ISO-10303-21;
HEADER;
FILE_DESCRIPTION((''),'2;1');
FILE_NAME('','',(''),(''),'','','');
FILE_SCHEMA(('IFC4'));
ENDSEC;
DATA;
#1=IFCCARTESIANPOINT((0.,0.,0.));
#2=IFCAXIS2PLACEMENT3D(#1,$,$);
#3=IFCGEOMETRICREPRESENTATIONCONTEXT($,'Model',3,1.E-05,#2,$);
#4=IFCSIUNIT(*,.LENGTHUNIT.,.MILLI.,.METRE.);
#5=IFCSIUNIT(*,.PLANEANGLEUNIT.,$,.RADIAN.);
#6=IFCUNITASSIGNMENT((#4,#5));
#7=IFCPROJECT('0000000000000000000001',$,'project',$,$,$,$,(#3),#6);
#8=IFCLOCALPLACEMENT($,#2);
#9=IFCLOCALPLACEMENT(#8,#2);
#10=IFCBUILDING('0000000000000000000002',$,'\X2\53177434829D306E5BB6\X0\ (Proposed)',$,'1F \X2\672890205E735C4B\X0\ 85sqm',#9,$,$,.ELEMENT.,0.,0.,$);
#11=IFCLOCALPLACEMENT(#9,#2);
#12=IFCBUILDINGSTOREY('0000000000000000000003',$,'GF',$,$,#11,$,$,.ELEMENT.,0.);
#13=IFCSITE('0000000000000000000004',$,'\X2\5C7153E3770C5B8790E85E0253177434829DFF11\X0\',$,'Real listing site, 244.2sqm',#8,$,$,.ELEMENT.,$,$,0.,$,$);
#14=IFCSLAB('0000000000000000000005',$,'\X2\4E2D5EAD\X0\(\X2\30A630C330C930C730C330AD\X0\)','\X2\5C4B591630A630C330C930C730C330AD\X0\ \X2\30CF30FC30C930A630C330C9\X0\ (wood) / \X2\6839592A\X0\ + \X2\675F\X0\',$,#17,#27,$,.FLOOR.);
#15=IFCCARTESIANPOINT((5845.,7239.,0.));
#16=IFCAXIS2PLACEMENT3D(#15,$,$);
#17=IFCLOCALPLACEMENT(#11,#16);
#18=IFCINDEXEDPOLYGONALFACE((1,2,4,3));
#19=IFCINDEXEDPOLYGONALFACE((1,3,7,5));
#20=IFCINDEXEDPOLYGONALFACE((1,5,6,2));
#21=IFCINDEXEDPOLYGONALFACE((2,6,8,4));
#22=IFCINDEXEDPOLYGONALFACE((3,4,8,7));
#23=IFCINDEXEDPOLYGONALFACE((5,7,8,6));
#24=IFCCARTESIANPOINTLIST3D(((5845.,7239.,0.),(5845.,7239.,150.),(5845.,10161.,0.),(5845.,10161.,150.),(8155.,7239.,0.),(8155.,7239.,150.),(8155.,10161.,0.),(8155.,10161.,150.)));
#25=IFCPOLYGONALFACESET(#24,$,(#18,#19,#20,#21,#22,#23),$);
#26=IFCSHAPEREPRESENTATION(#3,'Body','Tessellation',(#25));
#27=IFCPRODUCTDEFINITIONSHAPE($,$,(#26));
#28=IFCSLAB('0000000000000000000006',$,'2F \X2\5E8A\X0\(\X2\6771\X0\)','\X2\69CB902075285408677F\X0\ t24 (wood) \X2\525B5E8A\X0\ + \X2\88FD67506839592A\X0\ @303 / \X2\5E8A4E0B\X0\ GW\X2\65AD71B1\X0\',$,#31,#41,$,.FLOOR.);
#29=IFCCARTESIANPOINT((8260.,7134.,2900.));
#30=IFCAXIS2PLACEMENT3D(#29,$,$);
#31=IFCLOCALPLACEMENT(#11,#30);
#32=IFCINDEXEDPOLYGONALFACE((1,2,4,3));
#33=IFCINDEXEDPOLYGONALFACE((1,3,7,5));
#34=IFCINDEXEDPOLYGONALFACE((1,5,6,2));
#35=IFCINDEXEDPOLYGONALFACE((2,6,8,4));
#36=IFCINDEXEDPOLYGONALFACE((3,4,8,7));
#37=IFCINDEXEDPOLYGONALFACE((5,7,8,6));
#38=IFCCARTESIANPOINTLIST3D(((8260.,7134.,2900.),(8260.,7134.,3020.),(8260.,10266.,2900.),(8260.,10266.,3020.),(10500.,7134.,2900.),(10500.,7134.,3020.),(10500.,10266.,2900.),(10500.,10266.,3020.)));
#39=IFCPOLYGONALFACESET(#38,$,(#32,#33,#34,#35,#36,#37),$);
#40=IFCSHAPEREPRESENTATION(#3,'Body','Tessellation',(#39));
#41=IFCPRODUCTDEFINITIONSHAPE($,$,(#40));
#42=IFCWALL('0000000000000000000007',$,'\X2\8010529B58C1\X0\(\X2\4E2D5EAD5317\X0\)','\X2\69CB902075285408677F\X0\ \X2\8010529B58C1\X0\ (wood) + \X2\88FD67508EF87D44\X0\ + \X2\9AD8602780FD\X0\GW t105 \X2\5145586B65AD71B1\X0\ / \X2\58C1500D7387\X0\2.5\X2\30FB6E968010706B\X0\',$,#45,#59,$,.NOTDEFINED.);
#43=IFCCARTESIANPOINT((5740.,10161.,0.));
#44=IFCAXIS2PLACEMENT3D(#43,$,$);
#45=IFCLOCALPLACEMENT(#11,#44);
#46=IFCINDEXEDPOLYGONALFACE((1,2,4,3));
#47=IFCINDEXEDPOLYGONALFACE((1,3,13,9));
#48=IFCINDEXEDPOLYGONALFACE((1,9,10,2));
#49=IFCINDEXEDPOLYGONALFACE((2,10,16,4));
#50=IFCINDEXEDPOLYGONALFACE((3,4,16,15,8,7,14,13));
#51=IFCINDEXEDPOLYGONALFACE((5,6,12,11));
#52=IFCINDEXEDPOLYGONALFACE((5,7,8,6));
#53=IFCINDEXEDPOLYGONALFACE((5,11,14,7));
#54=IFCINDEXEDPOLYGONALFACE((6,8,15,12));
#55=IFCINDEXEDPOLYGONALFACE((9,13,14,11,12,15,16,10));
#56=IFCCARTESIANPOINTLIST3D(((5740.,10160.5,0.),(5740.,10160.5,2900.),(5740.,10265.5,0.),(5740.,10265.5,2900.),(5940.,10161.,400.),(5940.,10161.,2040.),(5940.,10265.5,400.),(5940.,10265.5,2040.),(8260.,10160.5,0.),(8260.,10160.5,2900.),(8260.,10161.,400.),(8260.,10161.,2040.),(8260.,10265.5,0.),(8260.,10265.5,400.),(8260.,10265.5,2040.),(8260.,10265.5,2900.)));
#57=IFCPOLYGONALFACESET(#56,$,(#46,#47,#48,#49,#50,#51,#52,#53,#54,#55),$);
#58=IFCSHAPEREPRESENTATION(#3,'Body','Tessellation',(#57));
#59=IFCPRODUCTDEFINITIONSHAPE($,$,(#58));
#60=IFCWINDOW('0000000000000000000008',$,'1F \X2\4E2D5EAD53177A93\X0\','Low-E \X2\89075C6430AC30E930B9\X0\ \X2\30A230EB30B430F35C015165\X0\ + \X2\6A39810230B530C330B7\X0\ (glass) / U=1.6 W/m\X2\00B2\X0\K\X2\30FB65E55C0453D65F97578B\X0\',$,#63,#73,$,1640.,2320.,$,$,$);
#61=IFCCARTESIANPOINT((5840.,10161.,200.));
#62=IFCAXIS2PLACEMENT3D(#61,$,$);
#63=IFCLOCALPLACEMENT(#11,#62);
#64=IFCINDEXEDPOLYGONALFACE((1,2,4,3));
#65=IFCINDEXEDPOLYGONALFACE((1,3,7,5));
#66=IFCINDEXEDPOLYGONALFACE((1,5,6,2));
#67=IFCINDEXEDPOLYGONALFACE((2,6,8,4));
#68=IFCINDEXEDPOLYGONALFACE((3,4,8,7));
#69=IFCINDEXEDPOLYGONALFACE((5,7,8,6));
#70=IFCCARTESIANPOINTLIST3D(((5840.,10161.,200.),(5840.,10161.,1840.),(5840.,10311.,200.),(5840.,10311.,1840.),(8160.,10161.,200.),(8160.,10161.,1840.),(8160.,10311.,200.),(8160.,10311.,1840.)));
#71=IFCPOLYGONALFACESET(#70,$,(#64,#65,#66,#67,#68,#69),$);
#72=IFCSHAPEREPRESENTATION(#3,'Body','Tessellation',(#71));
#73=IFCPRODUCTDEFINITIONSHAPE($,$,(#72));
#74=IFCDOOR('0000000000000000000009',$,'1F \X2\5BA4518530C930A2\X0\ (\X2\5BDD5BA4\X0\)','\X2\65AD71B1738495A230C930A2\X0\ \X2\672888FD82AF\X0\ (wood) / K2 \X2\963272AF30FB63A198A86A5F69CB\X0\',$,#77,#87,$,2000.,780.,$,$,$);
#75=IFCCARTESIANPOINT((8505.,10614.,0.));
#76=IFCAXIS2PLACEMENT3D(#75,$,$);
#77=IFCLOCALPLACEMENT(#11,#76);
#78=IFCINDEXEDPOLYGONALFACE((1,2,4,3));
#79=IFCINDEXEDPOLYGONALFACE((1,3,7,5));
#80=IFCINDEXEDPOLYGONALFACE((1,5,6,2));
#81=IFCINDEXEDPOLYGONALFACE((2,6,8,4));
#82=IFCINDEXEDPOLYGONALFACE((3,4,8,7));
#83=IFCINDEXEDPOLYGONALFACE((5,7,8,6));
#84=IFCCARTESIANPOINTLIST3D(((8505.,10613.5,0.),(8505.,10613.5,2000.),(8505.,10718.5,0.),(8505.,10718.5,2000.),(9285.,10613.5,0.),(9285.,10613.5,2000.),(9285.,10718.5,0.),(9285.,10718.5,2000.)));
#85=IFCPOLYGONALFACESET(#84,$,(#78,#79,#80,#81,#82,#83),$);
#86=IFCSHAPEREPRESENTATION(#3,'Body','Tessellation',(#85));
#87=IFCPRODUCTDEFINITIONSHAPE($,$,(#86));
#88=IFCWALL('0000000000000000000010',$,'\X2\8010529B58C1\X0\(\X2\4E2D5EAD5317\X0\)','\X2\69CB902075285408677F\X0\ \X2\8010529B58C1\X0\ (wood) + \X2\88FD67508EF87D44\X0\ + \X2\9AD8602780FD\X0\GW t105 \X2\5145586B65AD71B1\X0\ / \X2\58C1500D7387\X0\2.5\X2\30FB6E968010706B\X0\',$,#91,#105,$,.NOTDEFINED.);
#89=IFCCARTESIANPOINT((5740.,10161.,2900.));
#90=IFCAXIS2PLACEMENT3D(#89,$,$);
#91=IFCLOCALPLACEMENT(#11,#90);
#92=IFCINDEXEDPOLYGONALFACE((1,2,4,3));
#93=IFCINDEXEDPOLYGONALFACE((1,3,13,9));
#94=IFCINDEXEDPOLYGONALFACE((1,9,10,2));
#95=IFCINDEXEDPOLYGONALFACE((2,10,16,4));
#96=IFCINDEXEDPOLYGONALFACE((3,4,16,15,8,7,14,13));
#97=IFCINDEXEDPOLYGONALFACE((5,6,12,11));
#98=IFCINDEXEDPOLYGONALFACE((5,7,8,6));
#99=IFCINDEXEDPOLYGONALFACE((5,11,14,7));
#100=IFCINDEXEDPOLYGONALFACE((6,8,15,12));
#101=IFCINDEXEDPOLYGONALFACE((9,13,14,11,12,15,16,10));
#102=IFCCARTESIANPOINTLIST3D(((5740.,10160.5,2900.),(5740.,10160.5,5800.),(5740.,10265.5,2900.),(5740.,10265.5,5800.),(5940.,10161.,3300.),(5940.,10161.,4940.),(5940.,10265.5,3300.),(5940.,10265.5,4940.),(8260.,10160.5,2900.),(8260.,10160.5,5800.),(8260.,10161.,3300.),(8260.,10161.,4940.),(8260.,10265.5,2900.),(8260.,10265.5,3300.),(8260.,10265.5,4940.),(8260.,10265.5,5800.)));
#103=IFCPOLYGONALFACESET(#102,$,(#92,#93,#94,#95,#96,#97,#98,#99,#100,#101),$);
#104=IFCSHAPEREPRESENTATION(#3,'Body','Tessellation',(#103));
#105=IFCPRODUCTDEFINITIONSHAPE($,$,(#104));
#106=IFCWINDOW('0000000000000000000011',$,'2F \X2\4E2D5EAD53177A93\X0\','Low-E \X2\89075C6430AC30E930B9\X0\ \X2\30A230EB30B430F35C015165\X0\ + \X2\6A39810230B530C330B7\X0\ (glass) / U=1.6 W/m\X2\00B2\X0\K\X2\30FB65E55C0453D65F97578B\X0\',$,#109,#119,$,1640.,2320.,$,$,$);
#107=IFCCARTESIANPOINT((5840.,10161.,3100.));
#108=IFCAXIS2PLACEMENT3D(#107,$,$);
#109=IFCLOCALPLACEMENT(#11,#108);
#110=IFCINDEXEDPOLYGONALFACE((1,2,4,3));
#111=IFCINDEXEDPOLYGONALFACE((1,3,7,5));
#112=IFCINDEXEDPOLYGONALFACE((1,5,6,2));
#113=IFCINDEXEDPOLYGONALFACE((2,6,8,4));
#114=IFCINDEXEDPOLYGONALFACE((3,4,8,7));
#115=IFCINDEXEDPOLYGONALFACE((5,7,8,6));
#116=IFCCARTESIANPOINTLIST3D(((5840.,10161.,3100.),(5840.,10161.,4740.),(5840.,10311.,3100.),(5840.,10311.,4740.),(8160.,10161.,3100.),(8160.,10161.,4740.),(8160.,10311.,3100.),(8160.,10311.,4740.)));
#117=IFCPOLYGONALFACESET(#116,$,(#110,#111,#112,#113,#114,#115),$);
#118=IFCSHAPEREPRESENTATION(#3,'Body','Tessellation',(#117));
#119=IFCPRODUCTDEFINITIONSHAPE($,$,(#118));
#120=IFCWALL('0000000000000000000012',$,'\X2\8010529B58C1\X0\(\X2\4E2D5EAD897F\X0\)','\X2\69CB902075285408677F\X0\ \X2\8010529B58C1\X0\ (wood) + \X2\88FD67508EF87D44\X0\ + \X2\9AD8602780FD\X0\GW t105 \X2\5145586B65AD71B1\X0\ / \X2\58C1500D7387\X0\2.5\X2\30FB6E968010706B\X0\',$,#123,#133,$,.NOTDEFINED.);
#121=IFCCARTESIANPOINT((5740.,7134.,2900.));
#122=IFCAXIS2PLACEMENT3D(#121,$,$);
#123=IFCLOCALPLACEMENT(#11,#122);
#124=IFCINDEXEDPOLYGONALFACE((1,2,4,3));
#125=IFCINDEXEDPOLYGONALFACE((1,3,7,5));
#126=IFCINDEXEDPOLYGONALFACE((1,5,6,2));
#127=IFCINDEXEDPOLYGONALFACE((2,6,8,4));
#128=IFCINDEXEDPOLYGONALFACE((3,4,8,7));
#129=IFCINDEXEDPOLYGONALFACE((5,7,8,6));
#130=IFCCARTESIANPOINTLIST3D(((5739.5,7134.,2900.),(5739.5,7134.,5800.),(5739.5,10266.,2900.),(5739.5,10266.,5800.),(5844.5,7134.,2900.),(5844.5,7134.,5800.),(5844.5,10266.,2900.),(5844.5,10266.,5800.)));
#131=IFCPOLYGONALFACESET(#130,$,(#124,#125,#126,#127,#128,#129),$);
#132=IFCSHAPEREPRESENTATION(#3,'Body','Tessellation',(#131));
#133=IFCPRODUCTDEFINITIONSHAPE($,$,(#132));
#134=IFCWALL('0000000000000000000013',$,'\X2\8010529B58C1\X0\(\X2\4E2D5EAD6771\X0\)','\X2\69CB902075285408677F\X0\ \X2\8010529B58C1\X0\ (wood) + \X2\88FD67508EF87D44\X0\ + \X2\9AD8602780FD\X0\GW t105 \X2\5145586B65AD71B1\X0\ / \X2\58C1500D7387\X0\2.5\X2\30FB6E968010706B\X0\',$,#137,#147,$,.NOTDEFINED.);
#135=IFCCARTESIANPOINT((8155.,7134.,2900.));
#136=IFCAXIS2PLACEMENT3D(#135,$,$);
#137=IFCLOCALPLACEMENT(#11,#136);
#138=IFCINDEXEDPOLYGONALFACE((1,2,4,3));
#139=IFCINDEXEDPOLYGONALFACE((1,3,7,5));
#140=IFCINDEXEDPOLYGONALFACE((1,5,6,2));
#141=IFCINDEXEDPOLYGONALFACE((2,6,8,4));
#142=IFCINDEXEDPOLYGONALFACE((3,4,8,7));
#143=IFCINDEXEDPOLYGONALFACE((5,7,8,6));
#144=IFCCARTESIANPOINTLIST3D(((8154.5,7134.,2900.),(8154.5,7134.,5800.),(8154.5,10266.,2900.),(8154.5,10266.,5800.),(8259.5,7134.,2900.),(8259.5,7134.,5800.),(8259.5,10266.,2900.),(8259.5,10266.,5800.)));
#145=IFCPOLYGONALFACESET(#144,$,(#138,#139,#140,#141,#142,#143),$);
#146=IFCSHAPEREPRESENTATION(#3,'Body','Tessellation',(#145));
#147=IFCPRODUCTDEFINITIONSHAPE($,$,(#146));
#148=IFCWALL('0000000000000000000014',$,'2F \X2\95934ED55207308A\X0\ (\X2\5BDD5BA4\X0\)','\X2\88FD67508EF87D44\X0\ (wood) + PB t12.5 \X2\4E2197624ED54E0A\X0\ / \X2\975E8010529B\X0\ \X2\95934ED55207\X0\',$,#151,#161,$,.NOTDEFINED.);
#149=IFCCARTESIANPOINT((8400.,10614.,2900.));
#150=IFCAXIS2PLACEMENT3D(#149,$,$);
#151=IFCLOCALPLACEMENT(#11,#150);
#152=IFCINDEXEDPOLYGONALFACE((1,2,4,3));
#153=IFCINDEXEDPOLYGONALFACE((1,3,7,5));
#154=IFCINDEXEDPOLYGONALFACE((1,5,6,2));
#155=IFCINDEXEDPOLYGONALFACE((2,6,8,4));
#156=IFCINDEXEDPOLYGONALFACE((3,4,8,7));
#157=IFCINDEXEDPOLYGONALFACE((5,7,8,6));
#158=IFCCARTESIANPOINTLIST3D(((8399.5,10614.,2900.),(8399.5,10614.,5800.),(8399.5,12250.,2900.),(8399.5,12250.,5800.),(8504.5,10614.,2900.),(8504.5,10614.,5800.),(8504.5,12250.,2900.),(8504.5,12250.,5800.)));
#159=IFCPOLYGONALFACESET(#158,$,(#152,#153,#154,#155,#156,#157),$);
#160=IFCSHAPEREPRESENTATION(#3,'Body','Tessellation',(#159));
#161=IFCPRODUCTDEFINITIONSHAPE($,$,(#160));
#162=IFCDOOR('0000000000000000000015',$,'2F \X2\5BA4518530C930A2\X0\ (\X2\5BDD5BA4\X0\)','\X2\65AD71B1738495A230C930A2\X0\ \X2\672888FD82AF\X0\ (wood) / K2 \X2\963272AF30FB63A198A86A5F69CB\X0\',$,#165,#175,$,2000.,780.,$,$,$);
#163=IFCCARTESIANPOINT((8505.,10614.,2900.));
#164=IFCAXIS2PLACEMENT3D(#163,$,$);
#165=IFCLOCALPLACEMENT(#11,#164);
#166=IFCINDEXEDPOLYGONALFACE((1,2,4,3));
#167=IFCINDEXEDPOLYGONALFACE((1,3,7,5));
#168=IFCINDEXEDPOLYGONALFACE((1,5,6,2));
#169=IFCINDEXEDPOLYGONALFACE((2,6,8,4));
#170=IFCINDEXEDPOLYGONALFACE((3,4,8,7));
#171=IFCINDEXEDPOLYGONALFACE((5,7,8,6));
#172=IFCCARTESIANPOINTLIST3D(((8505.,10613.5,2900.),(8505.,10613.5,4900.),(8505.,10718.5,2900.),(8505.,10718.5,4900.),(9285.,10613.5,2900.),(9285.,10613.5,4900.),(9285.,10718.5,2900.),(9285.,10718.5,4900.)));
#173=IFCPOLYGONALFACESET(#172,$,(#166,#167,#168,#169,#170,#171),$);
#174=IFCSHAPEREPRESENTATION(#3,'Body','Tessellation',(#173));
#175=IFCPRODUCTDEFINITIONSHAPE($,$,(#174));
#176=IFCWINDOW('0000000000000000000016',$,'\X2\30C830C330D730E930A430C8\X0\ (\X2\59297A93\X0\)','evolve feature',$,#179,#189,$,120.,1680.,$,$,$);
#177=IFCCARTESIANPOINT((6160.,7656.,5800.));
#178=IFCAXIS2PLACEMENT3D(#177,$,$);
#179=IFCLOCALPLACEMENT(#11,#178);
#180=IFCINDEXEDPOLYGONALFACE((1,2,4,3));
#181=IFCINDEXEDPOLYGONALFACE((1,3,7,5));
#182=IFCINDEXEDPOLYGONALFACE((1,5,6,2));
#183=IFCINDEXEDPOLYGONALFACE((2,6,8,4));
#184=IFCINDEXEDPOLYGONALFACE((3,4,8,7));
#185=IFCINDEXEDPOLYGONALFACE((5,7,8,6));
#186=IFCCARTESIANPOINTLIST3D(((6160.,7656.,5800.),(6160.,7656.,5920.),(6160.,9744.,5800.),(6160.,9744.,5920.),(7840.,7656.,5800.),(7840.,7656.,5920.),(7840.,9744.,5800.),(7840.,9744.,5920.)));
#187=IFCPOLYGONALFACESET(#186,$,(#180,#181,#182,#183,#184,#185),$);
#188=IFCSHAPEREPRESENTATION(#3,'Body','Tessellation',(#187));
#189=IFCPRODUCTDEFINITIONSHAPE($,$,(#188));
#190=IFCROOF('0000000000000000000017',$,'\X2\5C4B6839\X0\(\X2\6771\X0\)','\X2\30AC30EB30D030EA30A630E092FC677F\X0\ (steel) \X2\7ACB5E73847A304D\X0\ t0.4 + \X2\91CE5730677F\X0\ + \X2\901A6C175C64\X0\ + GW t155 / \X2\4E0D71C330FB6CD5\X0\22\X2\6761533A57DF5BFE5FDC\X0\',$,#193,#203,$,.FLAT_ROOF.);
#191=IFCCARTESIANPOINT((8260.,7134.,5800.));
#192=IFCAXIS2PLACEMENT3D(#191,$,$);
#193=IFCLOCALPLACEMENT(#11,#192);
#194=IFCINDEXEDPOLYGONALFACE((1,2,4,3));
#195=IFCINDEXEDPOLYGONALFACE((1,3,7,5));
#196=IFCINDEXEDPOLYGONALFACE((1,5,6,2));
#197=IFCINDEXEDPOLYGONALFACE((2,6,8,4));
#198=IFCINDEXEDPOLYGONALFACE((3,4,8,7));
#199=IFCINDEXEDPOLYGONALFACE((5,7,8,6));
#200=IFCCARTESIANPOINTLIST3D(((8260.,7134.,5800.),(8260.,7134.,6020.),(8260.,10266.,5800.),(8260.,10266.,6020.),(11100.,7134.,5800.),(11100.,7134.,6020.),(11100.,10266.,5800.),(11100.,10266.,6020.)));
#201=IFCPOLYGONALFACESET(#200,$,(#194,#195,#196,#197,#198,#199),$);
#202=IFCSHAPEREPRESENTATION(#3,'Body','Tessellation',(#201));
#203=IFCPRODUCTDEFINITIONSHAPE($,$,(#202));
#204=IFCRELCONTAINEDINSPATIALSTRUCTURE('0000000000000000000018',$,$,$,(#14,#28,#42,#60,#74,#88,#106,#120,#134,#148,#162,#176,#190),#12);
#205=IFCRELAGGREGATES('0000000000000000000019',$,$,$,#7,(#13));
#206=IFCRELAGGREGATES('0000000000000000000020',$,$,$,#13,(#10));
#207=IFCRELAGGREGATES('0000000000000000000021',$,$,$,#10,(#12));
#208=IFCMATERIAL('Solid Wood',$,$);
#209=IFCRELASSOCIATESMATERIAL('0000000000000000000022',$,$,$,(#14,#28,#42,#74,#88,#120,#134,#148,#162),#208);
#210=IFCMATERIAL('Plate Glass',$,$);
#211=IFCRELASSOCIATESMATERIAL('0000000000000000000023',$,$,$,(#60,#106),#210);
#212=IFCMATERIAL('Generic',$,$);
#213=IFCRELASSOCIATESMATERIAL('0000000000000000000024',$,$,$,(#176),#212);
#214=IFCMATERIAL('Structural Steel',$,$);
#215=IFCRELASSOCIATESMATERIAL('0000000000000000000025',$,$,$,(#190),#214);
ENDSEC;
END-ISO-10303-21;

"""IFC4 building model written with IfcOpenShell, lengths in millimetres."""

from ifc_helpers import new_model, si_unit, frame, frame_2d, origin, place, context, project, spatial, rectangle, extrude, material, element, fill, save


model = new_model("IFC4")

# Units and contexts
model_context = context("Model", 3, precision=1e-05, world=origin())
ifc_project = project(units=[si_unit("LENGTHUNIT", "METRE", prefix="MILLI"), si_unit("PLANEANGLEUNIT", "RADIAN")], contexts=[model_context])

# Site, building, storey
site_placement = place(None, origin())
site = spatial("IfcSite", under=ifc_project, at=site_placement, Name="山口県宇部市北琴芝１", ObjectType="Real listing site, 244.2sqm", CompositionType="ELEMENT", RefElevation=0.0)
building_placement = place(site_placement, origin())
building = spatial("IfcBuilding", under=site, at=building_placement, Name="北琴芝の家 (Proposed)", ObjectType="1F 木造平屋 85sqm", CompositionType="ELEMENT", ElevationOfRefHeight=0.0, ElevationOfTerrain=0.0)
storey_placement = place(building_placement, origin())
storey = spatial("IfcBuildingStorey", under=building, at=storey_placement, Name="GF", CompositionType="ELEMENT", Elevation=0.0)

# Slabs
ifc_material_1 = material(Name="Solid Wood")
slab_1_placement = place(storey_placement, frame((5845.0, 7239.0, 0.0)))
element("IfcSlab", 1, at=slab_1_placement, inside=storey, material=ifc_material_1, Name="中庭(ウッドデッキ)", Description="屋外ウッドデッキ ハードウッド (wood) / 根太 + 束", PredefinedType="FLOOR", context=model_context, shape_type="SweptSolid", body=[
    extrude(rectangle(XDim=2310.0, YDim=2922.0, at=frame_2d((1155.0, 1461.0))), frame((5845.0, 7239.0, 0.0)), (0.0, 0.0, 1.0), 150.0),
])
slab_2_placement = place(storey_placement, frame((8260.0, 7134.0, 2900.0)))
element("IfcSlab", 2, at=slab_2_placement, inside=storey, material=ifc_material_1, Name="2F 床(東)", Description="構造用合板 t24 (wood) 剛床 + 製材根太 @303 / 床下 GW断熱", PredefinedType="FLOOR", context=model_context, shape_type="SweptSolid", body=[
    extrude(rectangle(XDim=2240.0, YDim=3132.0, at=frame_2d((1120.0, 1566.0))), frame((8260.0, 7134.0, 2900.0)), (0.0, 0.0, 1.0), 120.0),
])

# Wall, opening, window
wall_1_placement = place(storey_placement, frame((5740.0, 10161.0, 0.0)))
wall_1 = element("IfcWall", 3, at=wall_1_placement, inside=storey, material=ifc_material_1, Name="耐力壁(中庭北)", Description="構造用合板 耐力壁 (wood) + 製材軸組 + 高性能GW t105 充填断熱 / 壁倍率2.5・準耐火", PredefinedType="NOTDEFINED", context=model_context, shape_type="SweptSolid", body=[
    extrude(rectangle(XDim=2520.0, YDim=105.0, at=frame_2d((1260.0, 52.0))), frame((5740.0, 10161.0, 0.0)), (0.0, 0.0, 1.0), 2900.0),
])
opening_1_placement = place(storey_placement, frame((5840.0, 10161.0, 200.0)))
opening_1 = element("IfcOpeningElement", 4, at=opening_1_placement, cuts=wall_1, PredefinedType="NOTDEFINED", context=model_context, shape_type="SweptSolid", body=[
    extrude(rectangle(XDim=2320.0, YDim=150.0, at=frame_2d((1160.0, 75.0))), frame((5840.0, 10161.0, 200.0)), (0.0, 0.0, 1.0), 1640.0),
])
ifc_material_2 = material(Name="Plate Glass")
window_1_placement = place(storey_placement, frame((5840.0, 10161.0, 200.0)))
window_1 = element("IfcWindow", 5, at=window_1_placement, inside=storey, material=ifc_material_2, Name="1F 中庭北窓", Description="Low-E 複層ガラス アルゴン封入 + 樹脂サッシ (glass) / U=1.6 W/m²K・日射取得型", OverallHeight=1640.0, OverallWidth=2320.0, context=model_context, shape_type="SweptSolid", body=[
    extrude(rectangle(XDim=2320.0, YDim=150.0, at=frame_2d((1160.0, 75.0))), frame((5840.0, 10161.0, 200.0)), (0.0, 0.0, 1.0), 1640.0),
])
fill(opening_1, window_1)

# Door
door_1_placement = place(storey_placement, frame((8505.0, 10614.0, 0.0)))
element("IfcDoor", 6, at=door_1_placement, inside=storey, material=ifc_material_1, Name="1F 室内ドア (寝室)", Description="断熱玄関ドア 木製芯 (wood) / K2 防犯・採風機構", OverallHeight=2000.0, OverallWidth=780.0, context=model_context, shape_type="SweptSolid", body=[
    extrude(rectangle(XDim=780.0, YDim=105.0, at=frame_2d((390.0, 52.0))), frame((8505.0, 10614.0, 0.0)), (0.0, 0.0, 1.0), 2000.0),
])

# Wall, opening, window
wall_2_placement = place(storey_placement, frame((5740.0, 10161.0, 2900.0)))
wall_2 = element("IfcWall", 7, at=wall_2_placement, inside=storey, material=ifc_material_1, Name="耐力壁(中庭北)", Description="構造用合板 耐力壁 (wood) + 製材軸組 + 高性能GW t105 充填断熱 / 壁倍率2.5・準耐火", PredefinedType="NOTDEFINED", context=model_context, shape_type="SweptSolid", body=[
    extrude(rectangle(XDim=2520.0, YDim=105.0, at=frame_2d((1260.0, 52.0))), frame((5740.0, 10161.0, 2900.0)), (0.0, 0.0, 1.0), 2900.0),
])
opening_2_placement = place(storey_placement, frame((5840.0, 10161.0, 3100.0)))
opening_2 = element("IfcOpeningElement", 8, at=opening_2_placement, cuts=wall_2, PredefinedType="NOTDEFINED", context=model_context, shape_type="SweptSolid", body=[
    extrude(rectangle(XDim=2320.0, YDim=150.0, at=frame_2d((1160.0, 75.0))), frame((5840.0, 10161.0, 3100.0)), (0.0, 0.0, 1.0), 1640.0),
])
window_2_placement = place(storey_placement, frame((5840.0, 10161.0, 3100.0)))
window_2 = element("IfcWindow", 9, at=window_2_placement, inside=storey, material=ifc_material_2, Name="2F 中庭北窓", Description="Low-E 複層ガラス アルゴン封入 + 樹脂サッシ (glass) / U=1.6 W/m²K・日射取得型", OverallHeight=1640.0, OverallWidth=2320.0, context=model_context, shape_type="SweptSolid", body=[
    extrude(rectangle(XDim=2320.0, YDim=150.0, at=frame_2d((1160.0, 75.0))), frame((5840.0, 10161.0, 3100.0)), (0.0, 0.0, 1.0), 1640.0),
])
fill(opening_2, window_2)

# Walls
wall_3_placement = place(storey_placement, frame((5740.0, 7134.0, 2900.0)))
element("IfcWall", 10, at=wall_3_placement, inside=storey, material=ifc_material_1, Name="耐力壁(中庭西)", Description="構造用合板 耐力壁 (wood) + 製材軸組 + 高性能GW t105 充填断熱 / 壁倍率2.5・準耐火", PredefinedType="NOTDEFINED", context=model_context, shape_type="SweptSolid", body=[
    extrude(rectangle(XDim=105.0, YDim=3132.0, at=frame_2d((52.0, 1566.0))), frame((5740.0, 7134.0, 2900.0)), (0.0, 0.0, 1.0), 2900.0),
])
wall_4_placement = place(storey_placement, frame((8155.0, 7134.0, 2900.0)))
element("IfcWall", 11, at=wall_4_placement, inside=storey, material=ifc_material_1, Name="耐力壁(中庭東)", Description="構造用合板 耐力壁 (wood) + 製材軸組 + 高性能GW t105 充填断熱 / 壁倍率2.5・準耐火", PredefinedType="NOTDEFINED", context=model_context, shape_type="SweptSolid", body=[
    extrude(rectangle(XDim=105.0, YDim=3132.0, at=frame_2d((52.0, 1566.0))), frame((8155.0, 7134.0, 2900.0)), (0.0, 0.0, 1.0), 2900.0),
])
wall_5_placement = place(storey_placement, frame((8400.0, 10614.0, 2900.0)))
element("IfcWall", 12, at=wall_5_placement, inside=storey, material=ifc_material_1, Name="2F 間仕切り (寝室)", Description="製材軸組 (wood) + PB t12.5 両面仕上 / 非耐力 間仕切", PredefinedType="NOTDEFINED", context=model_context, shape_type="SweptSolid", body=[
    extrude(rectangle(XDim=105.0, YDim=1636.0, at=frame_2d((52.0, 818.0))), frame((8400.0, 10614.0, 2900.0)), (0.0, 0.0, 1.0), 2900.0),
])

# Door
door_2_placement = place(storey_placement, frame((8505.0, 10614.0, 2900.0)))
element("IfcDoor", 13, at=door_2_placement, inside=storey, material=ifc_material_1, Name="2F 室内ドア (寝室)", Description="断熱玄関ドア 木製芯 (wood) / K2 防犯・採風機構", OverallHeight=2000.0, OverallWidth=780.0, context=model_context, shape_type="SweptSolid", body=[
    extrude(rectangle(XDim=780.0, YDim=105.0, at=frame_2d((390.0, 52.0))), frame((8505.0, 10614.0, 2900.0)), (0.0, 0.0, 1.0), 2000.0),
])

# Window
ifc_material_3 = material(Name="Generic")
window_3_placement = place(storey_placement, frame((6160.0, 7656.0, 5800.0)))
element("IfcWindow", 14, at=window_3_placement, inside=storey, material=ifc_material_3, Name="トップライト (天窓)", Description="evolve feature", OverallHeight=120.0, OverallWidth=1680.0, context=model_context, shape_type="SweptSolid", body=[
    extrude(rectangle(XDim=1680.0, YDim=2088.0, at=frame_2d((840.0, 1044.0))), frame((6160.0, 7656.0, 5800.0)), (0.0, 0.0, 1.0), 120.0),
])

# Roof
ifc_material_4 = material(Name="Structural Steel")
roof_placement = place(storey_placement, frame((8260.0, 7134.0, 5800.0)))
element("IfcRoof", 15, at=roof_placement, inside=storey, material=ifc_material_4, Name="屋根(東)", Description="ガルバリウム鋼板 (steel) 立平葺き t0.4 + 野地板 + 通気層 + GW t155 / 不燃・法22条区域対応", PredefinedType="FLAT_ROOF", context=model_context, shape_type="SweptSolid", body=[
    extrude(rectangle(XDim=2840.0, YDim=3132.0, at=frame_2d((1420.0, 1566.0))), frame((8260.0, 7134.0, 5800.0)), (0.0, 0.0, 1.0), 220.0),
])

save(model, "model.ifc")
